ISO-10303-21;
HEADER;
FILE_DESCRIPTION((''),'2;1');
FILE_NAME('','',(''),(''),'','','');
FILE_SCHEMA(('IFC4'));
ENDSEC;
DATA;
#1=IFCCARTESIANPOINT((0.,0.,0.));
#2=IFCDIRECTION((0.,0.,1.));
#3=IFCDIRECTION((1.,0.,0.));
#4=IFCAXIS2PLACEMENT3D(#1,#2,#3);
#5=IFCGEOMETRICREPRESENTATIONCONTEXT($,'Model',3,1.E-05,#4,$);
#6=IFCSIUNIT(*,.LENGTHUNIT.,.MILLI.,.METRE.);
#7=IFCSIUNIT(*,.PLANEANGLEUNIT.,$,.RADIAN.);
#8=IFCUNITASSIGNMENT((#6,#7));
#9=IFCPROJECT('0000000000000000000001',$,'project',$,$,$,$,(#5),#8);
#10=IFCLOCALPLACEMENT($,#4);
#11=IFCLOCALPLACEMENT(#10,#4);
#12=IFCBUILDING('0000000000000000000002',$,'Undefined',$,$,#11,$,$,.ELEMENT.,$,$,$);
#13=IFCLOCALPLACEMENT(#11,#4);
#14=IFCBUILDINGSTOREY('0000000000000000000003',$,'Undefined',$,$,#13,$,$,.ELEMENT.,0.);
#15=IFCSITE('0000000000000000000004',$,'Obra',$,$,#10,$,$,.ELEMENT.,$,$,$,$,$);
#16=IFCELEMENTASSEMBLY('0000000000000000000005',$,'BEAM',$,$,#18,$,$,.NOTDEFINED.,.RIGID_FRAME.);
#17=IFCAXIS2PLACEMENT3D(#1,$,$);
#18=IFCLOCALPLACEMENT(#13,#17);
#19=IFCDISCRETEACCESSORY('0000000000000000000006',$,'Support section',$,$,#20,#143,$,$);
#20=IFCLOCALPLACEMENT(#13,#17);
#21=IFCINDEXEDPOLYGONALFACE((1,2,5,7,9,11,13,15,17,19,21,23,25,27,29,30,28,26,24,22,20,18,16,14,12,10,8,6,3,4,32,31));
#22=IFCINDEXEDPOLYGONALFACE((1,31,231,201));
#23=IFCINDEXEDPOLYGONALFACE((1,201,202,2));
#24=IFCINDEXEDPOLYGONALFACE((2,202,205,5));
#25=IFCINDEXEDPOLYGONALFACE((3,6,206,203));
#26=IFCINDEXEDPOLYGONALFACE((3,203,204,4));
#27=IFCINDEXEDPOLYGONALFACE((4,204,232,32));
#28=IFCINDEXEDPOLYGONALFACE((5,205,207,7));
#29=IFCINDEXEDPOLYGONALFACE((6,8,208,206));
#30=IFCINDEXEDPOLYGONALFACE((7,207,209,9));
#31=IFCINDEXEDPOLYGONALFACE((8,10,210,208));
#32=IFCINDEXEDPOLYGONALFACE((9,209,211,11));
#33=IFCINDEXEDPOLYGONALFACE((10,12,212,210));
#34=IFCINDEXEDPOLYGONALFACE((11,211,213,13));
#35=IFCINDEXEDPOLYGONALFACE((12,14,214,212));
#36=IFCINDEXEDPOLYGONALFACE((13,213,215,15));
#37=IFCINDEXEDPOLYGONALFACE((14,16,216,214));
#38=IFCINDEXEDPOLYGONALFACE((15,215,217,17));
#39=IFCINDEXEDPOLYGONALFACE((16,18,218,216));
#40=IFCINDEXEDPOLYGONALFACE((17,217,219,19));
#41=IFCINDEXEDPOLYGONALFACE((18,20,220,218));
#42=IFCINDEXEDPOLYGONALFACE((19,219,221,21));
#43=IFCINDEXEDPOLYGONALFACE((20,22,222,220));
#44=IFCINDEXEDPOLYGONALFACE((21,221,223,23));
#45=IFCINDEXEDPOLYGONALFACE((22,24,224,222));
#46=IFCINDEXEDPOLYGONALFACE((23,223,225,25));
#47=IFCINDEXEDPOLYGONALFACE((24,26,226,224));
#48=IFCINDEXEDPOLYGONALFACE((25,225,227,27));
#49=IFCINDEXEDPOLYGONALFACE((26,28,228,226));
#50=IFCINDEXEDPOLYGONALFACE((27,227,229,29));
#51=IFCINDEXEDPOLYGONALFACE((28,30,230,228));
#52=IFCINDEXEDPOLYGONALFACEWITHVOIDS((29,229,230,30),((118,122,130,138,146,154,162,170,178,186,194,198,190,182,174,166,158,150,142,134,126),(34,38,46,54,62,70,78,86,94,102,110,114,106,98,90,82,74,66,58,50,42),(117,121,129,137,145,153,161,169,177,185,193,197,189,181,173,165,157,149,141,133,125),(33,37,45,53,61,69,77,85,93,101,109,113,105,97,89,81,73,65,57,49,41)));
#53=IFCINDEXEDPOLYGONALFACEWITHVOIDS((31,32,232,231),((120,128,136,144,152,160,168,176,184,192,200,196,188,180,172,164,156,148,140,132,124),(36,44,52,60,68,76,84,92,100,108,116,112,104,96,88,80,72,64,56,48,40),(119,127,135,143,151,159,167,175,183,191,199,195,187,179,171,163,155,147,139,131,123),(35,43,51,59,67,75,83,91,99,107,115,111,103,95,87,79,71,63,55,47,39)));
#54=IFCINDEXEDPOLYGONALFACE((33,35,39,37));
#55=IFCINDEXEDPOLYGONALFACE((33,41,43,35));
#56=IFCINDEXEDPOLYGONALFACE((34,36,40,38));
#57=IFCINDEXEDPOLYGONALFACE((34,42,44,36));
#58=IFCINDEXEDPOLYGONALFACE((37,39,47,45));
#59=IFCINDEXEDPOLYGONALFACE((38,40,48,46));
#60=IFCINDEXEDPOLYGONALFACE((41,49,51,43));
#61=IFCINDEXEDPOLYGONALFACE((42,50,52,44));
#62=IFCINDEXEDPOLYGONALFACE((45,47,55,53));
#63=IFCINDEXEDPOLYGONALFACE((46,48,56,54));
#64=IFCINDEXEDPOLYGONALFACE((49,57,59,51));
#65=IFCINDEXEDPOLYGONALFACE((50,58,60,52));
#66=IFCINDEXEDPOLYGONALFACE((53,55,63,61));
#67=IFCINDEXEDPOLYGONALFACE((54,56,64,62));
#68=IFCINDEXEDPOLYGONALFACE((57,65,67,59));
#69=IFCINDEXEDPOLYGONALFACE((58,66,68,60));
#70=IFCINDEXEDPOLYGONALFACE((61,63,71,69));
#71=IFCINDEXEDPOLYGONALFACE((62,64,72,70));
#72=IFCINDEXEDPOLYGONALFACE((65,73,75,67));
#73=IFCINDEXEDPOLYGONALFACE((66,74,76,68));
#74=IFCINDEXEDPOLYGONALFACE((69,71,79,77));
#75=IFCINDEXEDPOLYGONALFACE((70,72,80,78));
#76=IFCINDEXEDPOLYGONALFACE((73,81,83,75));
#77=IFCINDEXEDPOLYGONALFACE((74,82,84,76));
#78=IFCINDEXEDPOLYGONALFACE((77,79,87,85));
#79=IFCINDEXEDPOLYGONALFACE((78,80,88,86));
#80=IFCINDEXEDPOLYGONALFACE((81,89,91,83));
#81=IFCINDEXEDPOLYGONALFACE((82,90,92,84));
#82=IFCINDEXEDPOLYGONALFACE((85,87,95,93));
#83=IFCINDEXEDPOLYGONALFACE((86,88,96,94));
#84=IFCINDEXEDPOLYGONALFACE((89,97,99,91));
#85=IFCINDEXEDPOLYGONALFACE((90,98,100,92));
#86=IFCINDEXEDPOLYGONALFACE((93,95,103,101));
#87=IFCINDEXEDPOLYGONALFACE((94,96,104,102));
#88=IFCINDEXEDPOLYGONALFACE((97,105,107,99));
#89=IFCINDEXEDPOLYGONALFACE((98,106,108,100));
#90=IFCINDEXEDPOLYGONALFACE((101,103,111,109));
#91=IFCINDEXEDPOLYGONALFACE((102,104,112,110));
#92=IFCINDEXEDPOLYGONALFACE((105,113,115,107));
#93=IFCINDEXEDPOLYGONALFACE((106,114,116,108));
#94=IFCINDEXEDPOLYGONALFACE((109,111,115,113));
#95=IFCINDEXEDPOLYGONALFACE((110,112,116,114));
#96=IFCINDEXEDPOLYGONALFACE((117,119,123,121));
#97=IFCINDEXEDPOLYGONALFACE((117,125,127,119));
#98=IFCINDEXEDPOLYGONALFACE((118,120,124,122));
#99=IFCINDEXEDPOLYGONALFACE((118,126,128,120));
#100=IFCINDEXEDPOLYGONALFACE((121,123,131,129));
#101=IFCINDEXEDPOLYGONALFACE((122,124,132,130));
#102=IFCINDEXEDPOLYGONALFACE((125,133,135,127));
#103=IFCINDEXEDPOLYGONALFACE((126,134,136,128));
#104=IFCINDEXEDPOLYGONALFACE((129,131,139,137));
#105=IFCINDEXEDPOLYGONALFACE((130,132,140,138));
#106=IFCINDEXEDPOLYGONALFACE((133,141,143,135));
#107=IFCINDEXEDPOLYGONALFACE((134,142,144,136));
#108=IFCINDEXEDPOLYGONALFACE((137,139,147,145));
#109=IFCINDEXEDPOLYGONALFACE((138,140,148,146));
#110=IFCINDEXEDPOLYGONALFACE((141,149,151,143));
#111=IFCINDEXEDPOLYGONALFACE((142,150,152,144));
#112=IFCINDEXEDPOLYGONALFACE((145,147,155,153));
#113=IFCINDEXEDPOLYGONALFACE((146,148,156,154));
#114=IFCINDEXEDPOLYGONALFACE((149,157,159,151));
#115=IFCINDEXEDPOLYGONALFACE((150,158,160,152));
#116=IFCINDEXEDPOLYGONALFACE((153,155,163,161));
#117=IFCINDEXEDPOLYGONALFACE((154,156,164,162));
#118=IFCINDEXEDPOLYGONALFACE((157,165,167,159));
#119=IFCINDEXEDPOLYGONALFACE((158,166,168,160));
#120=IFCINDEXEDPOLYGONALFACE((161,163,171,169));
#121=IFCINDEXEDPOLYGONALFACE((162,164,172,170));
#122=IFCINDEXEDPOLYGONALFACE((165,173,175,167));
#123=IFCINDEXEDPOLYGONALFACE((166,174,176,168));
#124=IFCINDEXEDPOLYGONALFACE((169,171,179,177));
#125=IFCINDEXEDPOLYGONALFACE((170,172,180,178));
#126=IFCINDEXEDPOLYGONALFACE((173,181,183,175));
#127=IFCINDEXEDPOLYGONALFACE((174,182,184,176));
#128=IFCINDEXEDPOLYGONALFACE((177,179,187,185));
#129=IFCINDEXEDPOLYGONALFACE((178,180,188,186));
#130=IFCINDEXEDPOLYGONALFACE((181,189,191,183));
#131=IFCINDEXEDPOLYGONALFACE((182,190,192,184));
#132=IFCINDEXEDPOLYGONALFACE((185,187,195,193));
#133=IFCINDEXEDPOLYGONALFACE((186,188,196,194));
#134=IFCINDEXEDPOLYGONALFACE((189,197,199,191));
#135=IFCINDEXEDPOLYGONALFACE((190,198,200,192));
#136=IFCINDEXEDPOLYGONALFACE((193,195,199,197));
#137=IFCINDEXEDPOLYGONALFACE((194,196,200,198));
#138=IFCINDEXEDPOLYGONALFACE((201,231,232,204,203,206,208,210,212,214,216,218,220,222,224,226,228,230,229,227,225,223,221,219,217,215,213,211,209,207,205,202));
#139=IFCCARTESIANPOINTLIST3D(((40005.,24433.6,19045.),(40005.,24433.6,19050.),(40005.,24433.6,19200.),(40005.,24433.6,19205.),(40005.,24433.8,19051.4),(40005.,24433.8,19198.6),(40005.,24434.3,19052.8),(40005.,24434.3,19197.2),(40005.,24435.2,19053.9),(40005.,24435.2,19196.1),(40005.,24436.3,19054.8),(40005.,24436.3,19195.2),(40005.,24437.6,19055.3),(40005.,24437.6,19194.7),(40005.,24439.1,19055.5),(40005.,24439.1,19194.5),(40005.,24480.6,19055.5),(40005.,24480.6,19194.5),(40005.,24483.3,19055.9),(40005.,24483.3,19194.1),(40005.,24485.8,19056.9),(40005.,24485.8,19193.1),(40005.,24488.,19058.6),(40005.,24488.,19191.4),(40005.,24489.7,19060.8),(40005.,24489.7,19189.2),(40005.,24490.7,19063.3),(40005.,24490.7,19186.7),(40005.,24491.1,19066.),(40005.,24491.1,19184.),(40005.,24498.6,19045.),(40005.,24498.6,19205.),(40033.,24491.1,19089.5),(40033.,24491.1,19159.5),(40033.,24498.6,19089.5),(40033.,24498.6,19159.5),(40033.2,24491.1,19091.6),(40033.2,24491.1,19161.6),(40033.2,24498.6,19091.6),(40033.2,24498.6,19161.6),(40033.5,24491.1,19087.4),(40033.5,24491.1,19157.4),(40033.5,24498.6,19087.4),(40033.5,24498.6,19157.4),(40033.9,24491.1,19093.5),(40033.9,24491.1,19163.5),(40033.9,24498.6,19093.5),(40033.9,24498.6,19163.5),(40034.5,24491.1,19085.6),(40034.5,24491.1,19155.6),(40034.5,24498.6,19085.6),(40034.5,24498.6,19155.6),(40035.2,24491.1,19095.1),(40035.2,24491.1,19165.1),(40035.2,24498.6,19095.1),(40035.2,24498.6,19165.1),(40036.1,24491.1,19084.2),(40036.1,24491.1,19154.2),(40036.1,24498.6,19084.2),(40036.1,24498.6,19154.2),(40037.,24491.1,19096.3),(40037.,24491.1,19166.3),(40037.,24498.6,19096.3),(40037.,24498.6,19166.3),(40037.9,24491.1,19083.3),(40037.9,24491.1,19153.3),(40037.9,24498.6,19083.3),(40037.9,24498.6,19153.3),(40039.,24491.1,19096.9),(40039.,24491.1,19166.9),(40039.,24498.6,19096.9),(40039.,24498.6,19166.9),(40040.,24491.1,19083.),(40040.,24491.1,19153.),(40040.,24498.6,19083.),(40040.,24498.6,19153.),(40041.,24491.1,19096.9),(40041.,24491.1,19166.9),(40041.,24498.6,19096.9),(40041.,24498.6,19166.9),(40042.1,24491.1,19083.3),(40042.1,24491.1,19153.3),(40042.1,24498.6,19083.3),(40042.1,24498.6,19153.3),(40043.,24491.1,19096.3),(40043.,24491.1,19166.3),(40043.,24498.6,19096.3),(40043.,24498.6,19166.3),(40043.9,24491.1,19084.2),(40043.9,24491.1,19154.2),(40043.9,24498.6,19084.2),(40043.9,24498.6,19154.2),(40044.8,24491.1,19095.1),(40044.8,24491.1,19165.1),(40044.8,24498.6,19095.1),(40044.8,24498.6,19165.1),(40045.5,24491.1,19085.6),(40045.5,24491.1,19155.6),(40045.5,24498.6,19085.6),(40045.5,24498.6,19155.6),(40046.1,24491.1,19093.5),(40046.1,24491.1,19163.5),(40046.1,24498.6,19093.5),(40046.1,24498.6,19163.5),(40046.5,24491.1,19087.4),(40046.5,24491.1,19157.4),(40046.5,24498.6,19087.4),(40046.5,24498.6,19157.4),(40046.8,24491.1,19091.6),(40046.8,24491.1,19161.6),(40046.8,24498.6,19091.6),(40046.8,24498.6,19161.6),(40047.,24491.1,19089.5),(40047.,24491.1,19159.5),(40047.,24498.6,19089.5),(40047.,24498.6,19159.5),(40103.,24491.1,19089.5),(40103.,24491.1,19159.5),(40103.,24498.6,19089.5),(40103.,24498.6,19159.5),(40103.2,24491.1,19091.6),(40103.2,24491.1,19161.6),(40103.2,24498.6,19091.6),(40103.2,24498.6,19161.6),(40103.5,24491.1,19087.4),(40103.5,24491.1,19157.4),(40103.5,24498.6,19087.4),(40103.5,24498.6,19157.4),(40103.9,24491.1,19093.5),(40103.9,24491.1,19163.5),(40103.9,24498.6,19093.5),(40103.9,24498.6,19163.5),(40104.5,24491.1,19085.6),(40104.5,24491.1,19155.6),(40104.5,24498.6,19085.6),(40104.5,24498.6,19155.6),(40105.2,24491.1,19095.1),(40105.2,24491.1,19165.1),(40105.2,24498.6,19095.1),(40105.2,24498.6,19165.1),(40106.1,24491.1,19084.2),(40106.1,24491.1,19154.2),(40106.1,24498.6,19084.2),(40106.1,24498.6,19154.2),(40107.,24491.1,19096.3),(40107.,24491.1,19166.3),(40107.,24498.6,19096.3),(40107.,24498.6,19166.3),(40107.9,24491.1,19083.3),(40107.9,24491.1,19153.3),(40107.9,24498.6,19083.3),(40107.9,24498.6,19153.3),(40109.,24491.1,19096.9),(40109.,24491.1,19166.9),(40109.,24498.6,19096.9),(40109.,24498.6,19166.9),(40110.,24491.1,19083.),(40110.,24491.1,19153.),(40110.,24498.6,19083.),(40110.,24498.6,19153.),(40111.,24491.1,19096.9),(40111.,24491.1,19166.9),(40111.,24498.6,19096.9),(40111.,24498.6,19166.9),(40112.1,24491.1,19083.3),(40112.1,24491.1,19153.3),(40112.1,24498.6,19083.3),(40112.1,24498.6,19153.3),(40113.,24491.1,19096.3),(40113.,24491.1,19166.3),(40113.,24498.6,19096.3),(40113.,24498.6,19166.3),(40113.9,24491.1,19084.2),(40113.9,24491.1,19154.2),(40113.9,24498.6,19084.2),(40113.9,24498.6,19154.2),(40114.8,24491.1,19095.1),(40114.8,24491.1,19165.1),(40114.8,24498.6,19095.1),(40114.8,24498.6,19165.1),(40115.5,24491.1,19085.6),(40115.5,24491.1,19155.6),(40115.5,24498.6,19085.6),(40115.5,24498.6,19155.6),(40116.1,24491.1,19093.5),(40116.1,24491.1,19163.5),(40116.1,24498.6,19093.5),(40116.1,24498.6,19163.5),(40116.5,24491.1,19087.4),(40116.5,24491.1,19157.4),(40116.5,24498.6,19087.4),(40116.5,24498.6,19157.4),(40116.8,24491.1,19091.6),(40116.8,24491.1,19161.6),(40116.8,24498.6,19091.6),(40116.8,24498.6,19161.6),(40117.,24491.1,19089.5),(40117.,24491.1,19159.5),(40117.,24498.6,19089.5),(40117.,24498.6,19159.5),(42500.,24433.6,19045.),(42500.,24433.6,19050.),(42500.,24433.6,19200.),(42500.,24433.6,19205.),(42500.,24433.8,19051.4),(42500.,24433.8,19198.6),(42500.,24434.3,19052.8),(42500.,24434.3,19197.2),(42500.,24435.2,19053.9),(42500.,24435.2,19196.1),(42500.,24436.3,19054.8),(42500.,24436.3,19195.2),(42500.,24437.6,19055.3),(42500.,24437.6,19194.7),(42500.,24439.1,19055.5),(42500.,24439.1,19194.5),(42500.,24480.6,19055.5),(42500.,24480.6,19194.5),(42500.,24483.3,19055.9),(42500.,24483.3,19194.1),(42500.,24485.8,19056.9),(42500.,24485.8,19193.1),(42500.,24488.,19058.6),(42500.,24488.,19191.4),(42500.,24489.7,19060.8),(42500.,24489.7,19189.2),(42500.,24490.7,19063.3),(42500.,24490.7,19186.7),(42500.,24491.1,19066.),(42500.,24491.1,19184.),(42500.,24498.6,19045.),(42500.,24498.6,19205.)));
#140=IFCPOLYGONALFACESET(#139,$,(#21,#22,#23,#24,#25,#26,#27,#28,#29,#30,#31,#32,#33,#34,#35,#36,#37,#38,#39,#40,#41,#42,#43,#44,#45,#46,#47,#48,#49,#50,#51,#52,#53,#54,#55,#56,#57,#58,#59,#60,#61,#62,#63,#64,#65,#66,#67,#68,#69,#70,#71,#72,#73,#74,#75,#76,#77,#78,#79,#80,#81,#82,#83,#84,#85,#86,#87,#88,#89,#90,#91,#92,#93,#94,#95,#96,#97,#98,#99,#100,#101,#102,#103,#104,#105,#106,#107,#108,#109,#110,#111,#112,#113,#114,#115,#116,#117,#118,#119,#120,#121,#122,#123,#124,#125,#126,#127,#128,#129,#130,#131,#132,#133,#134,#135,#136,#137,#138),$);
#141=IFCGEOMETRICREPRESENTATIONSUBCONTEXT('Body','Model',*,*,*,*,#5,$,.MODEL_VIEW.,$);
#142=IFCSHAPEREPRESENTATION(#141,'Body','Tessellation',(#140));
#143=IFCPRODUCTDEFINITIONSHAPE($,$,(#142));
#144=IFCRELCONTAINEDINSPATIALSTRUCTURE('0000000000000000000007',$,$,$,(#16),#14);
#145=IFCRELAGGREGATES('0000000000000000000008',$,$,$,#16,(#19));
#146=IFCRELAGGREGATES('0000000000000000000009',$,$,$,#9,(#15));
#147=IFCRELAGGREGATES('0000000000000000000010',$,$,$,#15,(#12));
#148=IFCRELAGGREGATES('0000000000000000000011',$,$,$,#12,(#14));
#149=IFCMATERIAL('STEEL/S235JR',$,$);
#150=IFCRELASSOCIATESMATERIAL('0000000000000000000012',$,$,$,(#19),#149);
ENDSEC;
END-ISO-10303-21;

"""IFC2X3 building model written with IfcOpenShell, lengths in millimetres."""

from ifc_helpers import new_model, si_unit, frame, origin_with_axes, origin_2d_with_axis, place, context, subcontext, project, spatial, circle, u_section, extrude, clip, halfspace, source, transform, mapped, material, element, aggregate, save


model = new_model("IFC2X3")

# Units and contexts
model_context = context("Model", 3, precision=1e-05, world=origin_with_axes())
body_context = subcontext(model_context, "Body", "Model", "MODEL_VIEW")
ifc_project = project(units=[si_unit("LENGTHUNIT", "METRE", prefix="MILLI"), si_unit("PLANEANGLEUNIT", "RADIAN")], contexts=[model_context])

# Site, building, storey
site_placement = place(None, origin_with_axes())
site = spatial("IfcSite", under=ifc_project, at=site_placement, Name="Obra", CompositionType="ELEMENT")
building_placement = place(site_placement, origin_with_axes())
building = spatial("IfcBuilding", under=site, at=building_placement, Name="Undefined", CompositionType="ELEMENT")
storey_placement = place(building_placement, origin_with_axes())
storey = spatial("IfcBuildingStorey", under=building, at=storey_placement, Name="Undefined", CompositionType="ELEMENT", Elevation=0.0)

# Shared definitions
ifc_material_1 = material(Name="STEEL/S235JR")

# Element assembly
assembly_1_placement = place(storey_placement, origin_with_axes())
assembly_1 = element("IfcElementAssembly", 1, at=assembly_1_placement, inside=storey, Name="BEAM", AssemblyPlace="NOTDEFINED", PredefinedType="RIGID_FRAME")

# Discrete accessory, opening
discrete_accessory_1_placement = place(assembly_1_placement, frame((40000.0, 24466.1, 19125.0), z_axis=(0.0, 0.0, 1.0), x_axis=(1.0, 0.0, 0.0)))
discrete_accessory_1 = element("IfcDiscreteAccessory", 2, at=discrete_accessory_1_placement, material=ifc_material_1, Name="Support section", context=body_context, shape_type="Clipping", body=[
    clip(extrude(u_section(Depth=160.0, FlangeWidth=65.0, WebThickness=7.5, FlangeThickness=10.5, FilletRadius=10.5, EdgeRadius=5.5, at=origin_2d_with_axis()), frame((2500.0, 0.0, 0.0), z_axis=(-1.0, 0.0, 0.0), x_axis=(0.0, -1.0, 0.0)), (0.0, 0.0, 1.0), 2495.0), halfspace(frame((5.0, 0.0, 166.3), z_axis=(-1.0, 0.0, 0.0), x_axis=(0.0, -1.0, 0.0)), False)),
])
shared_shape_1 = source(origin_with_axes(), body_context, "Body", "SweptSolid", [
    extrude(circle(Radius=7.0, at=origin_2d_with_axis()), frame((0.0, -3.9, 0.0), z_axis=(0.0, 1.0, 0.0), x_axis=(1.0, 0.0, 0.0)), (0.0, 0.0, 1.0), 7.7),
])
opening_1_placement = place(assembly_1_placement, frame((40040.0, 24494.8, 19160.0), z_axis=(1.0, 0.0, 0.0), x_axis=(0.0, 0.0, -1.0)))
element("IfcOpeningElement", 3, at=opening_1_placement, cuts=discrete_accessory_1, ObjectType="Opening", context=body_context, shape_type="MappedRepresentation", body=[
    mapped(shared_shape_1, transform((0.0, 0.0, 0.0))),
    mapped(shared_shape_1, transform((0.0, 0.0, 70.0))),
    mapped(shared_shape_1, transform((70.0, 0.0, 0.0))),
    mapped(shared_shape_1, transform((70.0, 0.0, 70.0))),
])
aggregate(assembly_1, [discrete_accessory_1])

save(model, "model.ifc")
